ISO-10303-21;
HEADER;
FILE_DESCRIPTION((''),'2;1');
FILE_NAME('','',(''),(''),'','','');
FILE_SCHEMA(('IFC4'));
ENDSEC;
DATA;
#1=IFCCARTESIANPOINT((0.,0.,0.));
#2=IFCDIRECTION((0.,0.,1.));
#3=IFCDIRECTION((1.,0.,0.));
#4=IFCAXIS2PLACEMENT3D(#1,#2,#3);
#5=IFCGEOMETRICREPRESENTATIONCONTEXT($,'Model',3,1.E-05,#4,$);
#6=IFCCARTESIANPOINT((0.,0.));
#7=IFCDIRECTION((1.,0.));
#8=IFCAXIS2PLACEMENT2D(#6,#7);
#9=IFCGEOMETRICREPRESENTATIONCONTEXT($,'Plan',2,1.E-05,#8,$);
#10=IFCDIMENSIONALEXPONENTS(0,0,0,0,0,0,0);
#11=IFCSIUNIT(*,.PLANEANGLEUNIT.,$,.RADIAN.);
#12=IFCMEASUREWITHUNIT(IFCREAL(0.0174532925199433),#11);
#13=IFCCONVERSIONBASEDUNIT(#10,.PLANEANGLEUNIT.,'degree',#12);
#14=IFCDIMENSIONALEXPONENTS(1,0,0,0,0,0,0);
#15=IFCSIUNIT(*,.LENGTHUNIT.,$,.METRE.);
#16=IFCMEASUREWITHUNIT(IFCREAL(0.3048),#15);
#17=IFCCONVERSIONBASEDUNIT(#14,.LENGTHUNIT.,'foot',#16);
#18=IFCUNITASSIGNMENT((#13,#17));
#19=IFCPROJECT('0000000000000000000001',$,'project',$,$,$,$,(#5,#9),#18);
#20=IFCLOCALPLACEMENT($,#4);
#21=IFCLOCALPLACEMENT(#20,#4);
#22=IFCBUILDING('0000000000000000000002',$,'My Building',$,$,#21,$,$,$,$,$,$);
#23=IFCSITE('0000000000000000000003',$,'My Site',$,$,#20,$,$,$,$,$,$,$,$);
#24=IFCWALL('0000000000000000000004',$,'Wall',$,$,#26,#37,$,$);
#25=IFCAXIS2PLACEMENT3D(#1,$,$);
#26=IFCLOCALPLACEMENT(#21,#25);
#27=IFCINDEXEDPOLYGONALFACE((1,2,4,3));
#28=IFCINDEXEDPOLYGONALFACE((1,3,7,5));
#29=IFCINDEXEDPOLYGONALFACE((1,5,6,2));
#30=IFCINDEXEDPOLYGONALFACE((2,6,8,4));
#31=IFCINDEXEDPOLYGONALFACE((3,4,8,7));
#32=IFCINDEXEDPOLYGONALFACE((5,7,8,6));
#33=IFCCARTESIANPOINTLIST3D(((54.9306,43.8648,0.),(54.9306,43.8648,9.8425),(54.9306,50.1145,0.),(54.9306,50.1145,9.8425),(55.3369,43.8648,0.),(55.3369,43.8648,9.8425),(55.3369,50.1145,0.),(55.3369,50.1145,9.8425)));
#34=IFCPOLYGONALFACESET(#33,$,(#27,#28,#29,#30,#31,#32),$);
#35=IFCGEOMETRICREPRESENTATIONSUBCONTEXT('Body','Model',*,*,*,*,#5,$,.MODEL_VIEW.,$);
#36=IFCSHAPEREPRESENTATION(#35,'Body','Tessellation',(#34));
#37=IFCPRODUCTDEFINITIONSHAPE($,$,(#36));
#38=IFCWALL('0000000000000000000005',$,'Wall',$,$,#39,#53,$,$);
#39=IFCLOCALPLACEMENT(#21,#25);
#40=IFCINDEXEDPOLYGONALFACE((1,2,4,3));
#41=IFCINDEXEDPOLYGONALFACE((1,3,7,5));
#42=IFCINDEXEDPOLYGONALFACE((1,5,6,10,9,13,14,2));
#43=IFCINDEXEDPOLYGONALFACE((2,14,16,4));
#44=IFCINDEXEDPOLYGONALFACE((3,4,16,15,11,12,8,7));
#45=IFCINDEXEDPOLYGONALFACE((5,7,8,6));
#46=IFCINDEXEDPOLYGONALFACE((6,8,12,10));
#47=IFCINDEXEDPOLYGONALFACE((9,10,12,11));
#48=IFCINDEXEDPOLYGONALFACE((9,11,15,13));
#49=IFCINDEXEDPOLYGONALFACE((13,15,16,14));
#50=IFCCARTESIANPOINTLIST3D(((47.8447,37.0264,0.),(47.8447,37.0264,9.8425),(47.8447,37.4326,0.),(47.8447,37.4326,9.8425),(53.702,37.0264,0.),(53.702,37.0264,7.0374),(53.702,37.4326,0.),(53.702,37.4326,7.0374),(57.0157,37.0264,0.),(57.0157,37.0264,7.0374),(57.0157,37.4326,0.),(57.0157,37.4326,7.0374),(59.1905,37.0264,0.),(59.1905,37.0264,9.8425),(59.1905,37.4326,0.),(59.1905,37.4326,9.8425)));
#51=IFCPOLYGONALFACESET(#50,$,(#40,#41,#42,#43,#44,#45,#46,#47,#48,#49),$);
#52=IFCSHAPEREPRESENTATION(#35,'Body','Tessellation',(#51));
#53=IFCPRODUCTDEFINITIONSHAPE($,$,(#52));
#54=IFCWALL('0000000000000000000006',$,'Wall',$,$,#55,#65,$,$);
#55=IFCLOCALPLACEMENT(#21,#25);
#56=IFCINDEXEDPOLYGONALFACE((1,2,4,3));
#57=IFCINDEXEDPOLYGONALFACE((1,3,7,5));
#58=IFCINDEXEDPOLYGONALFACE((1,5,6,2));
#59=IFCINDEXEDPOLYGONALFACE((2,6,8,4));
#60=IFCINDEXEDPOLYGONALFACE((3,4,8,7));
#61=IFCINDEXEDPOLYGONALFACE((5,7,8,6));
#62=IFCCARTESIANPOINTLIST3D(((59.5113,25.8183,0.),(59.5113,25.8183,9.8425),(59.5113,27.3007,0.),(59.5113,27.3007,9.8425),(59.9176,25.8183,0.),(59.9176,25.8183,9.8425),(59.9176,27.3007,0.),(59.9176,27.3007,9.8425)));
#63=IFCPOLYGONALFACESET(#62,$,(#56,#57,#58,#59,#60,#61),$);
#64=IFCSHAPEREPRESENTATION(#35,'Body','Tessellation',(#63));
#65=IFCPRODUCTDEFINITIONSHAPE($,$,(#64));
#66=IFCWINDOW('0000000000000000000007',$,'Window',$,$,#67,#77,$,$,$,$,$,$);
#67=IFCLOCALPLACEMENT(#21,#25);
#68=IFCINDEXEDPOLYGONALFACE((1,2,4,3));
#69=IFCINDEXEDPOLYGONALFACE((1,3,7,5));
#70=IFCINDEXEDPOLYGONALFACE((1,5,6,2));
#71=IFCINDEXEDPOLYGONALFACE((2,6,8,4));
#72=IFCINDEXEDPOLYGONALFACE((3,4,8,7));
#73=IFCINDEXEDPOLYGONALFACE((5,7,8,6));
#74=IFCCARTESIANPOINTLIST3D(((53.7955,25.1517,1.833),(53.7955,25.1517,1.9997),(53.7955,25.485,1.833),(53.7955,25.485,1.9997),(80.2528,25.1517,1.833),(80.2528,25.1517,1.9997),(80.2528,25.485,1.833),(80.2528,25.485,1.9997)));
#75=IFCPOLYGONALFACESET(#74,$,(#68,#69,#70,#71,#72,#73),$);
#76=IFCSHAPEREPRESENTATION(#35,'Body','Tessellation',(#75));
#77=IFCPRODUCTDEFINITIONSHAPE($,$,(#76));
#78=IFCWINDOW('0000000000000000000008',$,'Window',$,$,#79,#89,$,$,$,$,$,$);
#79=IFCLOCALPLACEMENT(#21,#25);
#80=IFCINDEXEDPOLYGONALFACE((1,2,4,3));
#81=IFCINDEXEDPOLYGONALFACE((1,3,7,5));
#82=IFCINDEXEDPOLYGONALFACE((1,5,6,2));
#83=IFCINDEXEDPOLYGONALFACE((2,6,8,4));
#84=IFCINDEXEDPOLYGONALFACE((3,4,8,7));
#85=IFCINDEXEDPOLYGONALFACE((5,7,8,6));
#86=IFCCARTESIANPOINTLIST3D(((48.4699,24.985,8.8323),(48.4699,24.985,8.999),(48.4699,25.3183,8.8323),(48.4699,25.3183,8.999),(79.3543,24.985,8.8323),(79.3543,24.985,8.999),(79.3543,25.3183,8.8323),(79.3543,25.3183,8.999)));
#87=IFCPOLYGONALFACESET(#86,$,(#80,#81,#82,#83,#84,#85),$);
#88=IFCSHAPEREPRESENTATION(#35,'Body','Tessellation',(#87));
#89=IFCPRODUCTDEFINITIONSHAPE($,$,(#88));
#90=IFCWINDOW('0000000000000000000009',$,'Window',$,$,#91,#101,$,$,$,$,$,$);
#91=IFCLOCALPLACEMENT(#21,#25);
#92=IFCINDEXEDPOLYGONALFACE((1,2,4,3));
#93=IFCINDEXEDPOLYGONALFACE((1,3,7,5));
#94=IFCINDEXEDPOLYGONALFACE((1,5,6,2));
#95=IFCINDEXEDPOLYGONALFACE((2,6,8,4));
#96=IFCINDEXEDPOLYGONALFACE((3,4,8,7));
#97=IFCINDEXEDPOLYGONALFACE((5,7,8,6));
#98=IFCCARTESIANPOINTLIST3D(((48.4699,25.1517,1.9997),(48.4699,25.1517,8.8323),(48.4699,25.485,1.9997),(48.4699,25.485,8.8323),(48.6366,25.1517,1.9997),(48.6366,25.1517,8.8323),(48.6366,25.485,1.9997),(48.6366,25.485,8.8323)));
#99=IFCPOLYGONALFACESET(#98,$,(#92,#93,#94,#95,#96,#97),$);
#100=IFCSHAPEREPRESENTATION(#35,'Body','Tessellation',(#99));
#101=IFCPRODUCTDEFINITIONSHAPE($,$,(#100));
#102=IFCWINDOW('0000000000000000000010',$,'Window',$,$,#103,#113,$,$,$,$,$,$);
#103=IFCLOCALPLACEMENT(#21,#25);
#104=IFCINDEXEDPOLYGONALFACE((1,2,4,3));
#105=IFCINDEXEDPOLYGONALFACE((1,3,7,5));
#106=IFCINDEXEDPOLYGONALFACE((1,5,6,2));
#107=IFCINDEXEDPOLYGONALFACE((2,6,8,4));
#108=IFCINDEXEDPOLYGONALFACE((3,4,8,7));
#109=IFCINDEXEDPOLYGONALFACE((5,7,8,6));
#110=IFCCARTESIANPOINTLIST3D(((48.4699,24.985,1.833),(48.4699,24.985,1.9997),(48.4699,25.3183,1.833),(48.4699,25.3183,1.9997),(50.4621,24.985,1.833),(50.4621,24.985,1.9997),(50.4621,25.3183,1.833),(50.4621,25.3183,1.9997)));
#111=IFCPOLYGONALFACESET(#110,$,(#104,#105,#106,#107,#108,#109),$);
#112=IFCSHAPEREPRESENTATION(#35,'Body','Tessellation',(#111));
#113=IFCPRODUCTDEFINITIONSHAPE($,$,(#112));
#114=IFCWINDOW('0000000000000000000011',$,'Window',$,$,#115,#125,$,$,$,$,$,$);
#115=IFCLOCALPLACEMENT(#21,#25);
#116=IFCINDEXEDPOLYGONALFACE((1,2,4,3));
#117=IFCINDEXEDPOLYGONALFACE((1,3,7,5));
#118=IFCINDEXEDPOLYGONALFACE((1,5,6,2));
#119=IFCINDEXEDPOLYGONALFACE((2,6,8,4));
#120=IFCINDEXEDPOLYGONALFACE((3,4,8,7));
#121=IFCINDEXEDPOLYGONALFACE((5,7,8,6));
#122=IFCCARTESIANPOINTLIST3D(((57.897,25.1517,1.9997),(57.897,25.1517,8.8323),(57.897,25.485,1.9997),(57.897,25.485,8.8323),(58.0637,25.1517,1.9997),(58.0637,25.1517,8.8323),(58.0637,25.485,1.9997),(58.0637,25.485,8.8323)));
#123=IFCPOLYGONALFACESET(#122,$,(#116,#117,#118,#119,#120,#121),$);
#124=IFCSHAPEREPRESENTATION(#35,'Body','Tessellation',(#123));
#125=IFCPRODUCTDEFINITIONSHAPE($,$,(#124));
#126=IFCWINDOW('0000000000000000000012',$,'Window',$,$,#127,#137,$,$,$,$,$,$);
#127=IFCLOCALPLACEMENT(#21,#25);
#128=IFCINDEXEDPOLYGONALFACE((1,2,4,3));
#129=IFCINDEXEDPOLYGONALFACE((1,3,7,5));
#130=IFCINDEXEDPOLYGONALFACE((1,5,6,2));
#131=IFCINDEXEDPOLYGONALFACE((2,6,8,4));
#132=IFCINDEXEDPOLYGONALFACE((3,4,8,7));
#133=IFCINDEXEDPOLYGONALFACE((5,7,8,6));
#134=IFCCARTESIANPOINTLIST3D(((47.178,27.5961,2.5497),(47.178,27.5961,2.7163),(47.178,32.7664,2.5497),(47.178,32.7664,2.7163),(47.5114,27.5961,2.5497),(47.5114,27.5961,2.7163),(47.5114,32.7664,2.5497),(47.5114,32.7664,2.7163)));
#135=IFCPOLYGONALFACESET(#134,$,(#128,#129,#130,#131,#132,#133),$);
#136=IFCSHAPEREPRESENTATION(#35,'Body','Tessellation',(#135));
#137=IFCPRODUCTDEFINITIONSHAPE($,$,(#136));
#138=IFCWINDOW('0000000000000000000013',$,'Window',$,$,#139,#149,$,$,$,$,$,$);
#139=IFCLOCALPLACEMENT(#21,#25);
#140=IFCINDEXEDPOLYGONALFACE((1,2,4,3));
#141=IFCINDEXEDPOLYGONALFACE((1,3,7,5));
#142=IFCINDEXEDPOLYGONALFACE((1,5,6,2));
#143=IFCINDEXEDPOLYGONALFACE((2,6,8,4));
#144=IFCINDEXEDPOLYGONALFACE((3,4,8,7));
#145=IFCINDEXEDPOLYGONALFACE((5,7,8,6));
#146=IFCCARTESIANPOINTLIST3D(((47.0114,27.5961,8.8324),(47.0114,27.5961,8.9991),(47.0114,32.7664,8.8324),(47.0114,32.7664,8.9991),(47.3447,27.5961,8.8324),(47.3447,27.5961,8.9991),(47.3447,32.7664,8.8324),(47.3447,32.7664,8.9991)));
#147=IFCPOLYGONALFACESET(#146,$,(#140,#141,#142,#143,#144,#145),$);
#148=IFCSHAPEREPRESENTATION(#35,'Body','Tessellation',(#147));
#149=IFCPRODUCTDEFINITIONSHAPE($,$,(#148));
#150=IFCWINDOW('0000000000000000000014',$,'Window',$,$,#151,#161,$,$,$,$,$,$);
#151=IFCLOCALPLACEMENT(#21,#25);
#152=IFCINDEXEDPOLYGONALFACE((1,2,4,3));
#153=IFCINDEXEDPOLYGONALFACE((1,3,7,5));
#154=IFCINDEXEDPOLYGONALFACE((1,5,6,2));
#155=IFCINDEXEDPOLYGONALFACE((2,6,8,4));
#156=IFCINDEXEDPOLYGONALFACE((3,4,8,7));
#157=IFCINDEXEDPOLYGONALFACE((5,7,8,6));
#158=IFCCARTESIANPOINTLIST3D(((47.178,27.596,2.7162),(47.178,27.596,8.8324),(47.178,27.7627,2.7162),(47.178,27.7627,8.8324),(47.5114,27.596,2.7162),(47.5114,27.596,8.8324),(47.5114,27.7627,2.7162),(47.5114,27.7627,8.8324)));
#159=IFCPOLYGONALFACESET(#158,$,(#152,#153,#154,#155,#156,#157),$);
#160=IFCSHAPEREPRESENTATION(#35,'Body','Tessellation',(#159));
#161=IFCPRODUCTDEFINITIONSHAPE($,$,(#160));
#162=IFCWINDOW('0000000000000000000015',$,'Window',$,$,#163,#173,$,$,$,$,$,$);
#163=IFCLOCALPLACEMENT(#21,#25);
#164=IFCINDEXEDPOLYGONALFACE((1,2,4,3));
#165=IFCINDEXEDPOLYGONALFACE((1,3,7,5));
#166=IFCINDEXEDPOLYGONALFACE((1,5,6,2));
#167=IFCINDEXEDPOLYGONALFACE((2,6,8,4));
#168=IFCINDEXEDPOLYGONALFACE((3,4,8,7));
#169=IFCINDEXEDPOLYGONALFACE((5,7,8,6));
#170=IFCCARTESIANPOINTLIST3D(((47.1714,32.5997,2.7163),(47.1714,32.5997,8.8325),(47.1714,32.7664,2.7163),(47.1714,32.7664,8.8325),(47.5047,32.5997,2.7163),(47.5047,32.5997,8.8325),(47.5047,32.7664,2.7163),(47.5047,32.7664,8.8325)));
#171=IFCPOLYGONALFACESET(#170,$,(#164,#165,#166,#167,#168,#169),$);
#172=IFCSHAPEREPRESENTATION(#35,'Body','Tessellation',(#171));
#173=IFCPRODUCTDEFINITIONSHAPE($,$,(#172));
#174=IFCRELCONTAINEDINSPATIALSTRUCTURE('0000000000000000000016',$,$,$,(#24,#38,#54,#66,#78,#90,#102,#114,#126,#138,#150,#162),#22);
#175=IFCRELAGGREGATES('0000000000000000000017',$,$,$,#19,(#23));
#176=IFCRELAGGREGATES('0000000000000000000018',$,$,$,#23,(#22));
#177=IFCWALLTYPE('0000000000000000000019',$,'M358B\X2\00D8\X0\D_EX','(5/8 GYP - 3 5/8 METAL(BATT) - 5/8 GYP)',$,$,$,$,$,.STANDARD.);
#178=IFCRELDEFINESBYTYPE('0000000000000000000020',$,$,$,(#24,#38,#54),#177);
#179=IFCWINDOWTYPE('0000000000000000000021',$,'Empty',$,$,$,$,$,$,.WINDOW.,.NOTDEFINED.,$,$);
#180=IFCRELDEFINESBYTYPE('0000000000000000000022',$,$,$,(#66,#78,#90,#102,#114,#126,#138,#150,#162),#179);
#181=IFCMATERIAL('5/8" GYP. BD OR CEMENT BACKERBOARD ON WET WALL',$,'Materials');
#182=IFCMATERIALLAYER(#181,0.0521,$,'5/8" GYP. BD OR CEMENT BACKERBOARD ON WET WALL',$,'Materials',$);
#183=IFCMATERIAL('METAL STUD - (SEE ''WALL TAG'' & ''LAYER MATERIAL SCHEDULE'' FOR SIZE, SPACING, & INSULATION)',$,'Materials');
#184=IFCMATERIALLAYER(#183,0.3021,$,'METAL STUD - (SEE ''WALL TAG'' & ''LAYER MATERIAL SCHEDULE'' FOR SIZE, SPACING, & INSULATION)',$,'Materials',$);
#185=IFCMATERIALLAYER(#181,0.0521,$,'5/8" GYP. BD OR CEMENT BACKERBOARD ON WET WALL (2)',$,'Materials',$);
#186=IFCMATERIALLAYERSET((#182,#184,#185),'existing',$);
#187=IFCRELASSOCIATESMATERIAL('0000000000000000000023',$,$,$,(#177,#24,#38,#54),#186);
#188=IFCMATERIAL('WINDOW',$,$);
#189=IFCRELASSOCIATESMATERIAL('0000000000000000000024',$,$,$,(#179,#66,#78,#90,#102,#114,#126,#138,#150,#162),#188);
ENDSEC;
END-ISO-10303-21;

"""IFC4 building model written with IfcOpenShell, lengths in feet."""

from ifc_helpers import new_model, entity, si_unit, converted_unit, frame, origin_with_axes, origin_2d_with_axis, place, context, subcontext, project, spatial, line, indexed_curve, rectangle, outline, extrude, source, transform, mapped, material, layer, layer_set, layer_usage, material_profile, profile_set, profile_usage, type_object, element, save


model = new_model("IFC4")

# Units and contexts
model_context = context("Model", 3, precision=1e-05, world=origin_with_axes())
plan_context = context("Plan", 2, precision=1e-05, world=origin_2d_with_axis())
body_context_1 = subcontext(model_context, "Body", "Model", "MODEL_VIEW")
ifc_project = project(units=[converted_unit("PLANEANGLEUNIT", "degree", entity("IfcReal", 0.0174532925199433), si_unit("PLANEANGLEUNIT", "RADIAN"), dimensions=[0, 0, 0, 0, 0, 0, 0]), converted_unit("LENGTHUNIT", "foot", entity("IfcReal", 0.3048), si_unit("LENGTHUNIT", "METRE"), dimensions=[1, 0, 0, 0, 0, 0, 0])], contexts=[model_context, plan_context])

# Site, building
site_placement = place(None, origin_with_axes())
site = spatial("IfcSite", under=ifc_project, at=site_placement, Name="My Site")
building_placement = place(site_placement, origin_with_axes())
building = spatial("IfcBuilding", under=site, at=building_placement, Name="My Building")

# Shared definitions
ifc_material_1 = material(Name="5/8\" GYP. BD OR CEMENT BACKERBOARD ON WET WALL", Category="Materials")
ifc_layer_1 = layer(ifc_material_1, 0.0521, Name="5/8\" GYP. BD OR CEMENT BACKERBOARD ON WET WALL", Category="Materials")
ifc_material_2 = material(Name="METAL STUD - (SEE 'WALL TAG' & 'LAYER MATERIAL SCHEDULE' FOR SIZE, SPACING, & INSULATION)", Category="Materials")
ifc_layer_2 = layer(ifc_material_2, 0.3021, Name="METAL STUD - (SEE 'WALL TAG' & 'LAYER MATERIAL SCHEDULE' FOR SIZE, SPACING, & INSULATION)", Category="Materials")
ifc_layer_3 = layer(ifc_material_1, 0.0521, Name="5/8\" GYP. BD OR CEMENT BACKERBOARD ON WET WALL (2)", Category="Materials")
ifc_layer_set_1 = layer_set([ifc_layer_1, ifc_layer_2, ifc_layer_3], Name="existing")
wall_type_1 = type_object("IfcWallType", Name="M358BØD_EX", Description="(5/8 GYP - 3 5/8 METAL(BATT) - 5/8 GYP)", PredefinedType="STANDARD", material=ifc_layer_set_1)

# Wall
ifc_layer_usage_1 = layer_usage(ifc_layer_set_1, "AXIS2", "POSITIVE", 0.0)
wall_1_placement = place(building_placement, frame((55.3369, 43.8648, 0.0), z_axis=(0.0, 0.0, 1.0), x_axis=(0.0, 1.0, 0.0)))
element("IfcWall", 1, at=wall_1_placement, inside=building, type_object=wall_type_1, material=ifc_layer_usage_1, Name="Wall", context=body_context_1, shape_type="SweptSolid", body=[
    extrude(outline(indexed_curve([(0.0, 0.0), (0.0, 0.4062), (6.2497, 0.4062), (6.2497, 0.0), (0.0, 0.0)], self_intersect=False)), origin_with_axes(), (0.0, 0.0, 1.0), 9.8425),
])

# Wall, opening
ifc_layer_usage_2 = layer_usage(ifc_layer_set_1, "AXIS2", "POSITIVE", 0.0)
wall_2_placement = place(building_placement, frame((47.8447, 37.0264, 0.0), z_axis=(0.0, 0.0, 1.0), x_axis=(1.0, 0.0, 0.0)))
wall_2 = element("IfcWall", 2, at=wall_2_placement, inside=building, type_object=wall_type_1, material=ifc_layer_usage_2, Name="Wall", context=body_context_1, shape_type="SweptSolid", body=[
    extrude(outline(indexed_curve([(0.0, 0.0), (0.0, 0.4062), (11.3457, 0.4062), (11.3457, 0.0), (0.0, 0.0)], self_intersect=False)), origin_with_axes(), (0.0, 0.0, 1.0), 9.8425),
])
shared_shape_1 = source(origin_with_axes(), body_context_1, "Body", "SweptSolid", [
    extrude(outline(indexed_curve([(0.0, 0.0), (3.3136, 0.0), (3.3136, 7.0374), (0.0, 7.0374)], segments=[line(1, 2), line(2, 3), line(3, 4), line(4, 1)])), frame((0.0, -0.3281, 0.0), z_axis=(0.0, -1.0, 0.0), x_axis=(1.0, 0.0, 0.0)), (0.0, 0.0, -1.0), 1.0624),
])
opening_1_placement = place(wall_2_placement, frame((5.8573, 0.0, 0.0), z_axis=(0.0, 0.0, 1.0), x_axis=(1.0, 0.0, 0.0)))
element("IfcOpeningElement", 3, at=opening_1_placement, cuts=wall_2, PredefinedType="OPENING", context=body_context_1, shape_type="MappedRepresentation", body=[
    mapped(shared_shape_1, transform((0.0, 0.0, 0.0), x_axis=(1.0, 0.0, 0.0), y_axis=(0.0, 1.0, 0.0), z_axis=(0.0, 0.0, 1.0), scale=1.0)),
])

# Wall
ifc_layer_usage_3 = layer_usage(ifc_layer_set_1, "AXIS2", "POSITIVE", 0.0)
wall_3_placement = place(building_placement, frame((59.9176, 25.8183, 0.0), z_axis=(0.0, 0.0, 1.0), x_axis=(0.000001, 1.0, 0.0)))
element("IfcWall", 4, at=wall_3_placement, inside=building, type_object=wall_type_1, material=ifc_layer_usage_3, Name="Wall", context=body_context_1, shape_type="SweptSolid", body=[
    extrude(outline(indexed_curve([(0.0, 0.0), (0.0, 0.4062), (1.4824, 0.4062), (1.4824, 0.0), (0.0, 0.0)], self_intersect=False)), origin_with_axes(), (0.0, 0.0, 1.0), 9.8425),
])

# Windows
ifc_material_3 = material(Name="WINDOW")
ifc_material_profile = material_profile(ifc_material_3, rectangle(XDim=0.3333, YDim=0.1667, at=origin_2d_with_axis()))
ifc_profile_set = profile_set([ifc_material_profile], Name="existing")
ifc_profile_usage_1 = profile_usage(ifc_profile_set, cardinal=5)
window_type = type_object("IfcWindowType", Name="Empty", PartitioningType="NOTDEFINED", PredefinedType="WINDOW", material=ifc_profile_set)
window_1_placement = place(building_placement, frame((53.7955, 25.3183, 1.9163), z_axis=(1.0, 0.0, 0.0), x_axis=(0.0, 1.0, 0.0)))
element("IfcWindow", 5, at=window_1_placement, inside=building, type_object=window_type, material=ifc_profile_usage_1, Name="Window", context=body_context_1, shape_type="SweptSolid", body=[
    extrude(rectangle(XDim=0.3333, YDim=0.1667, at=origin_2d_with_axis()), origin_with_axes(), (0.0, 0.0, 1.0), 26.4573),
])
ifc_profile_usage_2 = profile_usage(ifc_profile_set, cardinal=5)
window_2_placement = place(building_placement, frame((48.4699, 25.1517, 8.9157), z_axis=(1.0, 0.0, 0.0), x_axis=(0.0, 1.0, 0.0)))
element("IfcWindow", 6, at=window_2_placement, inside=building, type_object=window_type, material=ifc_profile_usage_2, Name="Window", context=body_context_1, shape_type="SweptSolid", body=[
    extrude(rectangle(XDim=0.3333, YDim=0.1667, at=origin_2d_with_axis()), origin_with_axes(), (0.0, 0.0, 1.0), 30.8843),
])
ifc_profile_usage_3 = profile_usage(ifc_profile_set, cardinal=5)
window_3_placement = place(building_placement, frame((48.5532, 25.3183, 1.9997), z_axis=(0.0, 0.0, 1.0), x_axis=(0.0, 1.0, 0.0)))
element("IfcWindow", 7, at=window_3_placement, inside=building, type_object=window_type, material=ifc_profile_usage_3, Name="Window", context=body_context_1, shape_type="SweptSolid", body=[
    extrude(rectangle(XDim=0.3333, YDim=0.1667, at=origin_2d_with_axis()), origin_with_axes(), (0.0, 0.0, 1.0), 6.8327),
])
ifc_profile_usage_4 = profile_usage(ifc_profile_set, cardinal=5)
window_4_placement = place(building_placement, frame((48.4699, 25.1517, 1.9163), z_axis=(1.0, 0.0, 0.0), x_axis=(0.0, 1.0, 0.0)))
element("IfcWindow", 8, at=window_4_placement, inside=building, type_object=window_type, material=ifc_profile_usage_4, Name="Window", context=body_context_1, shape_type="SweptSolid", body=[
    extrude(rectangle(XDim=0.3333, YDim=0.1667, at=origin_2d_with_axis()), origin_with_axes(), (0.0, 0.0, 1.0), 1.9922),
])
ifc_profile_usage_5 = profile_usage(ifc_profile_set, cardinal=5)
window_5_placement = place(building_placement, frame((57.9803, 25.3183, 1.9997), z_axis=(0.0, 0.0, 1.0), x_axis=(0.0, 1.0, 0.0)))
element("IfcWindow", 9, at=window_5_placement, inside=building, type_object=window_type, material=ifc_profile_usage_5, Name="Window", context=body_context_1, shape_type="SweptSolid", body=[
    extrude(rectangle(XDim=0.3333, YDim=0.1667, at=origin_2d_with_axis()), origin_with_axes(), (0.0, 0.0, 1.0), 6.8327),
])
ifc_profile_usage_6 = profile_usage(ifc_profile_set, cardinal=5)
window_6_placement = place(building_placement, frame((47.3447, 27.5961, 2.633), z_axis=(0.0, 1.0, 0.0), x_axis=(-1.0, 0.0, 0.0)))
element("IfcWindow", 10, at=window_6_placement, inside=building, type_object=window_type, material=ifc_profile_usage_6, Name="Window", context=body_context_1, shape_type="SweptSolid", body=[
    extrude(rectangle(XDim=0.3333, YDim=0.1667, at=origin_2d_with_axis()), origin_with_axes(), (0.0, 0.0, 1.0), 5.1703),
])
ifc_profile_usage_7 = profile_usage(ifc_profile_set, cardinal=5)
window_7_placement = place(building_placement, frame((47.178, 27.5961, 8.9157), z_axis=(0.0, 1.0, 0.0), x_axis=(-1.0, 0.0, 0.0)))
element("IfcWindow", 11, at=window_7_placement, inside=building, type_object=window_type, material=ifc_profile_usage_7, Name="Window", context=body_context_1, shape_type="SweptSolid", body=[
    extrude(rectangle(XDim=0.3333, YDim=0.1667, at=origin_2d_with_axis()), origin_with_axes(), (0.0, 0.0, 1.0), 5.1703),
])
ifc_profile_usage_8 = profile_usage(ifc_profile_set, cardinal=5)
window_8_placement = place(building_placement, frame((47.3447, 27.6793, 2.7162), z_axis=(0.0, 0.0, 1.0), x_axis=(-1.0, 0.0, 0.0)))
element("IfcWindow", 12, at=window_8_placement, inside=building, type_object=window_type, material=ifc_profile_usage_8, Name="Window", context=body_context_1, shape_type="SweptSolid", body=[
    extrude(rectangle(XDim=0.3333, YDim=0.1667, at=origin_2d_with_axis()), origin_with_axes(), (0.0, 0.0, 1.0), 6.1162),
])
ifc_profile_usage_9 = profile_usage(ifc_profile_set, cardinal=5)
window_9_placement = place(building_placement, frame((47.338, 32.6831, 2.7163), z_axis=(0.0, 0.0, 1.0), x_axis=(-1.0, 0.0, 0.0)))
element("IfcWindow", 13, at=window_9_placement, inside=building, type_object=window_type, material=ifc_profile_usage_9, Name="Window", context=body_context_1, shape_type="SweptSolid", body=[
    extrude(rectangle(XDim=0.3333, YDim=0.1667, at=origin_2d_with_axis()), origin_with_axes(), (0.0, 0.0, 1.0), 6.1162),
])

save(model, "model.ifc")
